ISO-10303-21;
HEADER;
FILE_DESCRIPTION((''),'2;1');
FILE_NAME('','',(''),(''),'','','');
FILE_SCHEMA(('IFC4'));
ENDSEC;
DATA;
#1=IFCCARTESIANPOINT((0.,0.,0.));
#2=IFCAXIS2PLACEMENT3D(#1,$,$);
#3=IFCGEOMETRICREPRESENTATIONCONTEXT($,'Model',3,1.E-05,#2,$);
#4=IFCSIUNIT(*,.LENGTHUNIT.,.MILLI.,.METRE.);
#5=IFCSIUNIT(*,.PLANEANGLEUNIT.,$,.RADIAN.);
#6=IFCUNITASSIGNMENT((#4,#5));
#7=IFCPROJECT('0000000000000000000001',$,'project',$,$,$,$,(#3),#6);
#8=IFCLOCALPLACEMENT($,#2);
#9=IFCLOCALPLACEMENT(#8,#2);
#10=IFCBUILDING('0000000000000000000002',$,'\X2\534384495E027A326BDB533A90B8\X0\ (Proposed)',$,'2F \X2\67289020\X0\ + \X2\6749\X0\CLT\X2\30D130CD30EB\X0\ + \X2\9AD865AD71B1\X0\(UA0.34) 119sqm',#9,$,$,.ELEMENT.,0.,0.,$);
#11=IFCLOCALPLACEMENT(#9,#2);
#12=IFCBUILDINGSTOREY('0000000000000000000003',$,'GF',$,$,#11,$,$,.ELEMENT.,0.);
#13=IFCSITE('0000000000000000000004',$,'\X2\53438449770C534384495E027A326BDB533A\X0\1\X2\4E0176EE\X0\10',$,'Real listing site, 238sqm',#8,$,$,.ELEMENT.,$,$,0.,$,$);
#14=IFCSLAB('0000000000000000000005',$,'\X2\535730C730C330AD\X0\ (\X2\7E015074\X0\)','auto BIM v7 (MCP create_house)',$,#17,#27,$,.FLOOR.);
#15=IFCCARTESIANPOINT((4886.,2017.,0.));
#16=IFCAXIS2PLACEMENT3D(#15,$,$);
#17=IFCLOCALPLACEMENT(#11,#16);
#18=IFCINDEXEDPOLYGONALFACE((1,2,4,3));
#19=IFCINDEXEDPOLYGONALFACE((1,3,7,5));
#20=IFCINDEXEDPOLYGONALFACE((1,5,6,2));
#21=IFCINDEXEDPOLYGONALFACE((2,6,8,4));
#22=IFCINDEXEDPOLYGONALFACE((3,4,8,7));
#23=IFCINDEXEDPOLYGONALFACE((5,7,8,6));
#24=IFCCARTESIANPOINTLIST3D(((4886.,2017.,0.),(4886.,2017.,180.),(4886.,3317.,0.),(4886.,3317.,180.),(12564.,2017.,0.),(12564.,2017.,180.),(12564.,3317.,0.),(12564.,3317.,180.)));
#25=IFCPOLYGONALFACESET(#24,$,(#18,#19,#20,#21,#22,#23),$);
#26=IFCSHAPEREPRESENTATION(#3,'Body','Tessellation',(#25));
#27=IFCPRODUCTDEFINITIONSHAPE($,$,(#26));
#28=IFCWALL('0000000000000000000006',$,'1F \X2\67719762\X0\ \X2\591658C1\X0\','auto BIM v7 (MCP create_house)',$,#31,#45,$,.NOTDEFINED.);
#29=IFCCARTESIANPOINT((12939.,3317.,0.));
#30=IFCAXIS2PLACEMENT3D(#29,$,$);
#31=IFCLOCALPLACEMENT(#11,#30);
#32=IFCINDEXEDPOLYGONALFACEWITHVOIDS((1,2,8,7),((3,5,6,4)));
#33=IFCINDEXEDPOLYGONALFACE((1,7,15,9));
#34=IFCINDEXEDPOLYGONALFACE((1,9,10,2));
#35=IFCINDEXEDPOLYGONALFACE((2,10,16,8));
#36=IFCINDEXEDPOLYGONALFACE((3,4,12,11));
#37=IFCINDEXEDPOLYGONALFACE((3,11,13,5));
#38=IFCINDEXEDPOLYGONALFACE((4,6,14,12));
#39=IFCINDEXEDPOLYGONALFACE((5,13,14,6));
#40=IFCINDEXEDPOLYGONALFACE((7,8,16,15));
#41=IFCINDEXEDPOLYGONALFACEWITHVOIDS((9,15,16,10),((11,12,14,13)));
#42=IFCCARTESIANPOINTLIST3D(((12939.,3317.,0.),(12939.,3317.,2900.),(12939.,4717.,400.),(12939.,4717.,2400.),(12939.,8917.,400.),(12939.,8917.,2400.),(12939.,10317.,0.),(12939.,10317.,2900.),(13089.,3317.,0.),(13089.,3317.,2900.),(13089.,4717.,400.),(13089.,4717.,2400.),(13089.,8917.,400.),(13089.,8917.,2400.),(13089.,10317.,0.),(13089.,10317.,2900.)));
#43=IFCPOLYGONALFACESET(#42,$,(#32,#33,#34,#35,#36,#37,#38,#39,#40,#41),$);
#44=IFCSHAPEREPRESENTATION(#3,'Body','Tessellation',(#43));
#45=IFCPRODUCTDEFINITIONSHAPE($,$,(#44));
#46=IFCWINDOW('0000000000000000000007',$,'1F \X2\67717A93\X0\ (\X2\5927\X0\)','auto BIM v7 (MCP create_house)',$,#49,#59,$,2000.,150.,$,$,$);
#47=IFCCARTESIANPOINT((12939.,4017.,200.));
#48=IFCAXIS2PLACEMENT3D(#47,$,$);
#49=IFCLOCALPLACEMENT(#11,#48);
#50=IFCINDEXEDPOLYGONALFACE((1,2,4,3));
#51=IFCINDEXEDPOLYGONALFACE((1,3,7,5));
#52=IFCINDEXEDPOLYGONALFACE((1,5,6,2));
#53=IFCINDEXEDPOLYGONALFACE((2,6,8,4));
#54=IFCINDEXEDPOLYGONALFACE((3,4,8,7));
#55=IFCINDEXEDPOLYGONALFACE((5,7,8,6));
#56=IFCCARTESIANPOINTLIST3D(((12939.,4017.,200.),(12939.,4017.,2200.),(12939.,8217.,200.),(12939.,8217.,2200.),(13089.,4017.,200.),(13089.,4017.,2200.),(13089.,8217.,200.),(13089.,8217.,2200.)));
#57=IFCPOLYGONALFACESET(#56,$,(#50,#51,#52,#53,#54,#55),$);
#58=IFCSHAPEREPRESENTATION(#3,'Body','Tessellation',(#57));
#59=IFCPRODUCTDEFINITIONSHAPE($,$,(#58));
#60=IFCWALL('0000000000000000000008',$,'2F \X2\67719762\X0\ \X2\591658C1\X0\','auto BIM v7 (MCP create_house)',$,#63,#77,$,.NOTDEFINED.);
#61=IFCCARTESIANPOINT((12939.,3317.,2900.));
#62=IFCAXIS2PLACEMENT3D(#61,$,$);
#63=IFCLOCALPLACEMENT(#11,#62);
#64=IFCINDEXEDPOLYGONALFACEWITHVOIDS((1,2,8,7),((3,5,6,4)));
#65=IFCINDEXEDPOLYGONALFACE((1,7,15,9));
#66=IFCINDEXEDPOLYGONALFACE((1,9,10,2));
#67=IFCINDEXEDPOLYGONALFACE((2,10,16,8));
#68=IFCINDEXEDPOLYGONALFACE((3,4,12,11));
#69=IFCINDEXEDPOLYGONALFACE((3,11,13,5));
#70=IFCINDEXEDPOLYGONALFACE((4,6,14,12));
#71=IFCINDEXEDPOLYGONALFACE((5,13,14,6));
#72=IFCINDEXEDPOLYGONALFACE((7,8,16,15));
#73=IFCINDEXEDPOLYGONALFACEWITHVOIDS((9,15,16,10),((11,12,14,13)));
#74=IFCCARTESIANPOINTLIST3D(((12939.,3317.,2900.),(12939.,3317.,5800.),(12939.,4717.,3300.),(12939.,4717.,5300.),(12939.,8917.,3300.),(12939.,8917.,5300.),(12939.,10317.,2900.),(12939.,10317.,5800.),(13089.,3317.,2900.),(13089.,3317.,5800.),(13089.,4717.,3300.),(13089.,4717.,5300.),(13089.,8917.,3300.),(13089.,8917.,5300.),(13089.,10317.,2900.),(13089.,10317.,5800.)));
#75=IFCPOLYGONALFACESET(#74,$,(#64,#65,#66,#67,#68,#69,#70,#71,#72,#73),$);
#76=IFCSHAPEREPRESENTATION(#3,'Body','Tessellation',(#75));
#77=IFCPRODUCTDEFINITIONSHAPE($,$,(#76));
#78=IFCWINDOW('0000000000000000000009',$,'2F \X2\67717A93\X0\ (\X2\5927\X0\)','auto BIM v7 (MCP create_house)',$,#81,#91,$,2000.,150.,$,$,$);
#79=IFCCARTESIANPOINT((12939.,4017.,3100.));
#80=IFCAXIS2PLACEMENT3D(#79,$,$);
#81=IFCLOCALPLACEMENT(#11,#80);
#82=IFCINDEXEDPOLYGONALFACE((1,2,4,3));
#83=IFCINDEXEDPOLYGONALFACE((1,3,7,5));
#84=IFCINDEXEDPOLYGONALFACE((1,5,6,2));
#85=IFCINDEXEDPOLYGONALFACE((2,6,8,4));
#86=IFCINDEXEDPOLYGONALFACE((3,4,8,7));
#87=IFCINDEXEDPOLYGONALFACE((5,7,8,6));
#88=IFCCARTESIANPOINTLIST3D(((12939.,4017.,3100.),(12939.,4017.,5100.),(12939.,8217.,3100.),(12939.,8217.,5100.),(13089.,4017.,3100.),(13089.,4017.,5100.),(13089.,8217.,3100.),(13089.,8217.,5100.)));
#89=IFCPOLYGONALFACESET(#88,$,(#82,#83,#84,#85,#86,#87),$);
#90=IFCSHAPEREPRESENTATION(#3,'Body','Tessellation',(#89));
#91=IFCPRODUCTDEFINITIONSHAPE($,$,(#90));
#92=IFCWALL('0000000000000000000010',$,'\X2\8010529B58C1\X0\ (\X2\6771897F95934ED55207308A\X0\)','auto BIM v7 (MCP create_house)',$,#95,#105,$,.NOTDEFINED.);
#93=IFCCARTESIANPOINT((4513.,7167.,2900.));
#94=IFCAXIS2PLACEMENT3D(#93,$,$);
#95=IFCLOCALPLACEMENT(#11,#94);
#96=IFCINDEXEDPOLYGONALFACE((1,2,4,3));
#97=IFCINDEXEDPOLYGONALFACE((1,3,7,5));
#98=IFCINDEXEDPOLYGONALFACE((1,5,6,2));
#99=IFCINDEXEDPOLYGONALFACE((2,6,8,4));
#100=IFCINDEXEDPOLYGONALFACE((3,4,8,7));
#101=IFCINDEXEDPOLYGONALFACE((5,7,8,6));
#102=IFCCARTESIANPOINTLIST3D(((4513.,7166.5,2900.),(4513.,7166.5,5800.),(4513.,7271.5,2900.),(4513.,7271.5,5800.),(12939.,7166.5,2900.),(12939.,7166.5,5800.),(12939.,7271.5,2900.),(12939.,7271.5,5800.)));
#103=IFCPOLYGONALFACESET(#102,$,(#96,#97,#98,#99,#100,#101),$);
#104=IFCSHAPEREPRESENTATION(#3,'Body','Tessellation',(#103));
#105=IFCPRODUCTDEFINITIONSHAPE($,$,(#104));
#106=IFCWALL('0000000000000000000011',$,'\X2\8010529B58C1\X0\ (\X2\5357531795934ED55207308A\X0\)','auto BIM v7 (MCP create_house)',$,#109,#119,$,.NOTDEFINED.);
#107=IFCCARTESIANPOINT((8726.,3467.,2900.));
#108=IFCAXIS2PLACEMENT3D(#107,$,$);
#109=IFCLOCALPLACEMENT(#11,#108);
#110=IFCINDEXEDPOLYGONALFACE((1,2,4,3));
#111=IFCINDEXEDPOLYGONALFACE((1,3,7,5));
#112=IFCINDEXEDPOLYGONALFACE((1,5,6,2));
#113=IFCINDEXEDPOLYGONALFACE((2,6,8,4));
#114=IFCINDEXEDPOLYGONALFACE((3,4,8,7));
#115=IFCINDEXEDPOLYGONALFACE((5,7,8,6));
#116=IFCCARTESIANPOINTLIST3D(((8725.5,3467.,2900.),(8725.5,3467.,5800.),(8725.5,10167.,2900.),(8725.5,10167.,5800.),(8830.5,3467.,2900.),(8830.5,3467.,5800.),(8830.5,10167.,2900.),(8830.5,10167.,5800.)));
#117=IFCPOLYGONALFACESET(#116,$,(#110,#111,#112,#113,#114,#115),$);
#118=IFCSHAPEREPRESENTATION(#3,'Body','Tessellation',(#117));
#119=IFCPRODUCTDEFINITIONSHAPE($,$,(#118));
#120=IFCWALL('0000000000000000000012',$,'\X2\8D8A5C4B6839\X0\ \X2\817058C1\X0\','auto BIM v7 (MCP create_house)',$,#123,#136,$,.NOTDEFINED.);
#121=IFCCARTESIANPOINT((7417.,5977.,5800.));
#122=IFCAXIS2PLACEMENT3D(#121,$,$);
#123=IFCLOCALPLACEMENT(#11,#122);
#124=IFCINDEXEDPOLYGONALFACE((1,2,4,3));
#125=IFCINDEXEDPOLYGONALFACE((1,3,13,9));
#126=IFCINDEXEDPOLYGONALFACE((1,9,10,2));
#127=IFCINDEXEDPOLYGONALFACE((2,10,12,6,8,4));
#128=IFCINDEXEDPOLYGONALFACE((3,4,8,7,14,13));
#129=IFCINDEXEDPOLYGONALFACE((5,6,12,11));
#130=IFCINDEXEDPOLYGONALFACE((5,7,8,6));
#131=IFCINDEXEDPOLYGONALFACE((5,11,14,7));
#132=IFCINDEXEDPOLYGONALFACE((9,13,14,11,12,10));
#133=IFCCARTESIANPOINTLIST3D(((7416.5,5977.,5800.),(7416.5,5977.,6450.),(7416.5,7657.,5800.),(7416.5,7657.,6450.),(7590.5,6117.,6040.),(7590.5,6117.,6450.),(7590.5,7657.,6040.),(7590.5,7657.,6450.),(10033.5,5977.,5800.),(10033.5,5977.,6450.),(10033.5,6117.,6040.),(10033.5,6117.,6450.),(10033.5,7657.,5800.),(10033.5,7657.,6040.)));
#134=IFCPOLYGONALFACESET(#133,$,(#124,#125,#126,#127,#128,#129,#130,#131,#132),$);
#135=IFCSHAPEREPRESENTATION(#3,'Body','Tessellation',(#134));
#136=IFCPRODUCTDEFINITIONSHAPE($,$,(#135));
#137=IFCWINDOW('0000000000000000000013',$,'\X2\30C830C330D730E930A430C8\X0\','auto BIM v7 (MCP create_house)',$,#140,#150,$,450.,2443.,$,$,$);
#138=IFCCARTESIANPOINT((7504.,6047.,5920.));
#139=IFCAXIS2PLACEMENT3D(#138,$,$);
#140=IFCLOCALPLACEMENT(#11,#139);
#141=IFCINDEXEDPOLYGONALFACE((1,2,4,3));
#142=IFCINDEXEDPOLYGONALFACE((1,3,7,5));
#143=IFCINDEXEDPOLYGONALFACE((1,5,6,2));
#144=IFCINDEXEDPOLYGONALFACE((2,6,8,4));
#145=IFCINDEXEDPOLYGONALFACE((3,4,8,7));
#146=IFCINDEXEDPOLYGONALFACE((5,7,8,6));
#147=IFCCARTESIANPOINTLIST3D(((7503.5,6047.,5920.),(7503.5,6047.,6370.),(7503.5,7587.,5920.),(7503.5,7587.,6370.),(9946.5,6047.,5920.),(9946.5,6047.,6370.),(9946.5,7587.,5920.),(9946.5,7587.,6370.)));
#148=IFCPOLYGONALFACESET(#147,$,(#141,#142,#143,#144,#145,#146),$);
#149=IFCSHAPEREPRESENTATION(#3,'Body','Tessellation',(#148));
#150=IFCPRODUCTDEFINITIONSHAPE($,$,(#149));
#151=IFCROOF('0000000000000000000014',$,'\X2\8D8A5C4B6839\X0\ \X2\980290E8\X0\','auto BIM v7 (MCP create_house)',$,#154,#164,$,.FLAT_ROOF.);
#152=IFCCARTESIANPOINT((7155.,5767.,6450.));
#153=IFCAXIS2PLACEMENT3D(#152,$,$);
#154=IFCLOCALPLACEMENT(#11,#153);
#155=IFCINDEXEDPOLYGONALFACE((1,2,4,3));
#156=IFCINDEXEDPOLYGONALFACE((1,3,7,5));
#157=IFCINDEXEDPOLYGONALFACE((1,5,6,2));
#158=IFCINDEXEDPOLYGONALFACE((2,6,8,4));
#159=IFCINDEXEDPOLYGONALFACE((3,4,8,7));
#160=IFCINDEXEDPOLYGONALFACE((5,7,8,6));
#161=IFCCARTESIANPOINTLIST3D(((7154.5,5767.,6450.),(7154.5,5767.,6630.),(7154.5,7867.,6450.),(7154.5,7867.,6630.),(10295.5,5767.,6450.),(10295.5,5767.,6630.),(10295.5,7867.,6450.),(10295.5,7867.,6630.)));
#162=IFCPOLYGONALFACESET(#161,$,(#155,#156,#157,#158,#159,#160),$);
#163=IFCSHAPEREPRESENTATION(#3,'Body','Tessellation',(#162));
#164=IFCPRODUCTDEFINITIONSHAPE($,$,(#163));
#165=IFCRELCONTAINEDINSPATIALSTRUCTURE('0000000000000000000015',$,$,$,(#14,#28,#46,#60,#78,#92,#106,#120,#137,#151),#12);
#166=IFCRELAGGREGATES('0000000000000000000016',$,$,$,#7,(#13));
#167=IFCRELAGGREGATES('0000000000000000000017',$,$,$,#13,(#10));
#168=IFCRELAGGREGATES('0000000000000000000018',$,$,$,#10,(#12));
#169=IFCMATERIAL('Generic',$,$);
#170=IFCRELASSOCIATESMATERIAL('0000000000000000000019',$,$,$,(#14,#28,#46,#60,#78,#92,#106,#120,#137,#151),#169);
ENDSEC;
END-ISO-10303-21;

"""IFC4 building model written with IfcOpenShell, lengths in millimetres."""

from ifc_helpers import new_model, si_unit, frame, frame_2d, origin, place, context, project, spatial, rectangle, extrude, material, element, fill, save


model = new_model("IFC4")

# Units and contexts
model_context = context("Model", 3, precision=1e-05, world=origin())
ifc_project = project(units=[si_unit("LENGTHUNIT", "METRE", prefix="MILLI"), si_unit("PLANEANGLEUNIT", "RADIAN")], contexts=[model_context])

# Site, building, storey
site_placement = place(None, origin())
site = spatial("IfcSite", under=ifc_project, at=site_placement, Name="千葉県千葉市稲毛区1丁目10", ObjectType="Real listing site, 238sqm", CompositionType="ELEMENT", RefElevation=0.0)
building_placement = place(site_placement, origin())
building = spatial("IfcBuilding", under=site, at=building_placement, Name="千葉市稲毛区邸 (Proposed)", ObjectType="2F 木造 + 杉CLTパネル + 高断熱(UA0.34) 119sqm", CompositionType="ELEMENT", ElevationOfRefHeight=0.0, ElevationOfTerrain=0.0)
storey_placement = place(building_placement, origin())
storey = spatial("IfcBuildingStorey", under=building, at=storey_placement, Name="GF", CompositionType="ELEMENT", Elevation=0.0)

# Slab
ifc_material = material(Name="Generic")
slab_placement = place(storey_placement, frame((4886.0, 2017.0, 0.0)))
element("IfcSlab", 1, at=slab_placement, inside=storey, material=ifc_material, Name="南デッキ (縁側)", Description="auto BIM v7 (MCP create_house)", PredefinedType="FLOOR", context=model_context, shape_type="SweptSolid", body=[
    extrude(rectangle(XDim=7678.0, YDim=1300.0, at=frame_2d((3839.0, 650.0))), frame((4886.0, 2017.0, 0.0)), (0.0, 0.0, 1.0), 180.0),
])

# Wall, opening, window
wall_1_placement = place(storey_placement, frame((12939.0, 3317.0, 0.0)))
wall_1 = element("IfcWall", 2, at=wall_1_placement, inside=storey, material=ifc_material, Name="1F 東面 外壁", Description="auto BIM v7 (MCP create_house)", PredefinedType="NOTDEFINED", context=model_context, shape_type="SweptSolid", body=[
    extrude(rectangle(XDim=150.0, YDim=7000.0, at=frame_2d((75.0, 3500.0))), frame((12939.0, 3317.0, 0.0)), (0.0, 0.0, 1.0), 2900.0),
])
opening_1_placement = place(storey_placement, frame((12939.0, 4017.0, 200.0)))
opening_1 = element("IfcOpeningElement", 3, at=opening_1_placement, cuts=wall_1, PredefinedType="NOTDEFINED", context=model_context, shape_type="SweptSolid", body=[
    extrude(rectangle(XDim=150.0, YDim=4200.0, at=frame_2d((75.0, 2100.0))), frame((12939.0, 4017.0, 200.0)), (0.0, 0.0, 1.0), 2000.0),
])
window_1_placement = place(storey_placement, frame((12939.0, 4017.0, 200.0)))
window_1 = element("IfcWindow", 4, at=window_1_placement, inside=storey, material=ifc_material, Name="1F 東窓 (大)", Description="auto BIM v7 (MCP create_house)", OverallHeight=2000.0, OverallWidth=150.0, context=model_context, shape_type="SweptSolid", body=[
    extrude(rectangle(XDim=150.0, YDim=4200.0, at=frame_2d((75.0, 2100.0))), frame((12939.0, 4017.0, 200.0)), (0.0, 0.0, 1.0), 2000.0),
])
fill(opening_1, window_1)

# Wall, opening, window
wall_2_placement = place(storey_placement, frame((12939.0, 3317.0, 2900.0)))
wall_2 = element("IfcWall", 5, at=wall_2_placement, inside=storey, material=ifc_material, Name="2F 東面 外壁", Description="auto BIM v7 (MCP create_house)", PredefinedType="NOTDEFINED", context=model_context, shape_type="SweptSolid", body=[
    extrude(rectangle(XDim=150.0, YDim=7000.0, at=frame_2d((75.0, 3500.0))), frame((12939.0, 3317.0, 2900.0)), (0.0, 0.0, 1.0), 2900.0),
])
opening_2_placement = place(storey_placement, frame((12939.0, 4017.0, 3100.0)))
opening_2 = element("IfcOpeningElement", 6, at=opening_2_placement, cuts=wall_2, PredefinedType="NOTDEFINED", context=model_context, shape_type="SweptSolid", body=[
    extrude(rectangle(XDim=150.0, YDim=4200.0, at=frame_2d((75.0, 2100.0))), frame((12939.0, 4017.0, 3100.0)), (0.0, 0.0, 1.0), 2000.0),
])
window_2_placement = place(storey_placement, frame((12939.0, 4017.0, 3100.0)))
window_2 = element("IfcWindow", 7, at=window_2_placement, inside=storey, material=ifc_material, Name="2F 東窓 (大)", Description="auto BIM v7 (MCP create_house)", OverallHeight=2000.0, OverallWidth=150.0, context=model_context, shape_type="SweptSolid", body=[
    extrude(rectangle(XDim=150.0, YDim=4200.0, at=frame_2d((75.0, 2100.0))), frame((12939.0, 4017.0, 3100.0)), (0.0, 0.0, 1.0), 2000.0),
])
fill(opening_2, window_2)

# Walls
wall_3_placement = place(storey_placement, frame((4513.0, 7167.0, 2900.0)))
element("IfcWall", 8, at=wall_3_placement, inside=storey, material=ifc_material, Name="耐力壁 (東西間仕切り)", Description="auto BIM v7 (MCP create_house)", PredefinedType="NOTDEFINED", context=model_context, shape_type="SweptSolid", body=[
    extrude(rectangle(XDim=8426.0, YDim=105.0, at=frame_2d((4213.0, 52.0))), frame((4513.0, 7167.0, 2900.0)), (0.0, 0.0, 1.0), 2900.0),
])
wall_4_placement = place(storey_placement, frame((8726.0, 3467.0, 2900.0)))
element("IfcWall", 9, at=wall_4_placement, inside=storey, material=ifc_material, Name="耐力壁 (南北間仕切り)", Description="auto BIM v7 (MCP create_house)", PredefinedType="NOTDEFINED", context=model_context, shape_type="SweptSolid", body=[
    extrude(rectangle(XDim=105.0, YDim=6700.0, at=frame_2d((52.0, 3350.0))), frame((8726.0, 3467.0, 2900.0)), (0.0, 0.0, 1.0), 2900.0),
])

# Wall, opening, window
wall_5_placement = place(storey_placement, frame((7417.0, 5977.0, 5800.0)))
wall_5 = element("IfcWall", 10, at=wall_5_placement, inside=storey, material=ifc_material, Name="越屋根 腰壁", Description="auto BIM v7 (MCP create_house)", PredefinedType="NOTDEFINED", context=model_context, shape_type="SweptSolid", body=[
    extrude(rectangle(XDim=2617.0, YDim=1680.0, at=frame_2d((1308.0, 840.0))), frame((7417.0, 5977.0, 5800.0)), (0.0, 0.0, 1.0), 650.0),
])
opening_3_placement = place(storey_placement, frame((7504.0, 6047.0, 5920.0)))
opening_3 = element("IfcOpeningElement", 11, at=opening_3_placement, cuts=wall_5, PredefinedType="NOTDEFINED", context=model_context, shape_type="SweptSolid", body=[
    extrude(rectangle(XDim=2443.0, YDim=1540.0, at=frame_2d((1221.0, 770.0))), frame((7504.0, 6047.0, 5920.0)), (0.0, 0.0, 1.0), 450.0),
])
window_3_placement = place(storey_placement, frame((7504.0, 6047.0, 5920.0)))
window_3 = element("IfcWindow", 12, at=window_3_placement, inside=storey, material=ifc_material, Name="トップライト", Description="auto BIM v7 (MCP create_house)", OverallHeight=450.0, OverallWidth=2443.0, context=model_context, shape_type="SweptSolid", body=[
    extrude(rectangle(XDim=2443.0, YDim=1540.0, at=frame_2d((1221.0, 770.0))), frame((7504.0, 6047.0, 5920.0)), (0.0, 0.0, 1.0), 450.0),
])
fill(opening_3, window_3)

# Roof
roof_placement = place(storey_placement, frame((7155.0, 5767.0, 6450.0)))
element("IfcRoof", 13, at=roof_placement, inside=storey, material=ifc_material, Name="越屋根 頂部", Description="auto BIM v7 (MCP create_house)", PredefinedType="FLAT_ROOF", context=model_context, shape_type="SweptSolid", body=[
    extrude(rectangle(XDim=3141.0, YDim=2100.0, at=frame_2d((1570.0, 1050.0))), frame((7155.0, 5767.0, 6450.0)), (0.0, 0.0, 1.0), 180.0),
])

save(model, "model.ifc")
